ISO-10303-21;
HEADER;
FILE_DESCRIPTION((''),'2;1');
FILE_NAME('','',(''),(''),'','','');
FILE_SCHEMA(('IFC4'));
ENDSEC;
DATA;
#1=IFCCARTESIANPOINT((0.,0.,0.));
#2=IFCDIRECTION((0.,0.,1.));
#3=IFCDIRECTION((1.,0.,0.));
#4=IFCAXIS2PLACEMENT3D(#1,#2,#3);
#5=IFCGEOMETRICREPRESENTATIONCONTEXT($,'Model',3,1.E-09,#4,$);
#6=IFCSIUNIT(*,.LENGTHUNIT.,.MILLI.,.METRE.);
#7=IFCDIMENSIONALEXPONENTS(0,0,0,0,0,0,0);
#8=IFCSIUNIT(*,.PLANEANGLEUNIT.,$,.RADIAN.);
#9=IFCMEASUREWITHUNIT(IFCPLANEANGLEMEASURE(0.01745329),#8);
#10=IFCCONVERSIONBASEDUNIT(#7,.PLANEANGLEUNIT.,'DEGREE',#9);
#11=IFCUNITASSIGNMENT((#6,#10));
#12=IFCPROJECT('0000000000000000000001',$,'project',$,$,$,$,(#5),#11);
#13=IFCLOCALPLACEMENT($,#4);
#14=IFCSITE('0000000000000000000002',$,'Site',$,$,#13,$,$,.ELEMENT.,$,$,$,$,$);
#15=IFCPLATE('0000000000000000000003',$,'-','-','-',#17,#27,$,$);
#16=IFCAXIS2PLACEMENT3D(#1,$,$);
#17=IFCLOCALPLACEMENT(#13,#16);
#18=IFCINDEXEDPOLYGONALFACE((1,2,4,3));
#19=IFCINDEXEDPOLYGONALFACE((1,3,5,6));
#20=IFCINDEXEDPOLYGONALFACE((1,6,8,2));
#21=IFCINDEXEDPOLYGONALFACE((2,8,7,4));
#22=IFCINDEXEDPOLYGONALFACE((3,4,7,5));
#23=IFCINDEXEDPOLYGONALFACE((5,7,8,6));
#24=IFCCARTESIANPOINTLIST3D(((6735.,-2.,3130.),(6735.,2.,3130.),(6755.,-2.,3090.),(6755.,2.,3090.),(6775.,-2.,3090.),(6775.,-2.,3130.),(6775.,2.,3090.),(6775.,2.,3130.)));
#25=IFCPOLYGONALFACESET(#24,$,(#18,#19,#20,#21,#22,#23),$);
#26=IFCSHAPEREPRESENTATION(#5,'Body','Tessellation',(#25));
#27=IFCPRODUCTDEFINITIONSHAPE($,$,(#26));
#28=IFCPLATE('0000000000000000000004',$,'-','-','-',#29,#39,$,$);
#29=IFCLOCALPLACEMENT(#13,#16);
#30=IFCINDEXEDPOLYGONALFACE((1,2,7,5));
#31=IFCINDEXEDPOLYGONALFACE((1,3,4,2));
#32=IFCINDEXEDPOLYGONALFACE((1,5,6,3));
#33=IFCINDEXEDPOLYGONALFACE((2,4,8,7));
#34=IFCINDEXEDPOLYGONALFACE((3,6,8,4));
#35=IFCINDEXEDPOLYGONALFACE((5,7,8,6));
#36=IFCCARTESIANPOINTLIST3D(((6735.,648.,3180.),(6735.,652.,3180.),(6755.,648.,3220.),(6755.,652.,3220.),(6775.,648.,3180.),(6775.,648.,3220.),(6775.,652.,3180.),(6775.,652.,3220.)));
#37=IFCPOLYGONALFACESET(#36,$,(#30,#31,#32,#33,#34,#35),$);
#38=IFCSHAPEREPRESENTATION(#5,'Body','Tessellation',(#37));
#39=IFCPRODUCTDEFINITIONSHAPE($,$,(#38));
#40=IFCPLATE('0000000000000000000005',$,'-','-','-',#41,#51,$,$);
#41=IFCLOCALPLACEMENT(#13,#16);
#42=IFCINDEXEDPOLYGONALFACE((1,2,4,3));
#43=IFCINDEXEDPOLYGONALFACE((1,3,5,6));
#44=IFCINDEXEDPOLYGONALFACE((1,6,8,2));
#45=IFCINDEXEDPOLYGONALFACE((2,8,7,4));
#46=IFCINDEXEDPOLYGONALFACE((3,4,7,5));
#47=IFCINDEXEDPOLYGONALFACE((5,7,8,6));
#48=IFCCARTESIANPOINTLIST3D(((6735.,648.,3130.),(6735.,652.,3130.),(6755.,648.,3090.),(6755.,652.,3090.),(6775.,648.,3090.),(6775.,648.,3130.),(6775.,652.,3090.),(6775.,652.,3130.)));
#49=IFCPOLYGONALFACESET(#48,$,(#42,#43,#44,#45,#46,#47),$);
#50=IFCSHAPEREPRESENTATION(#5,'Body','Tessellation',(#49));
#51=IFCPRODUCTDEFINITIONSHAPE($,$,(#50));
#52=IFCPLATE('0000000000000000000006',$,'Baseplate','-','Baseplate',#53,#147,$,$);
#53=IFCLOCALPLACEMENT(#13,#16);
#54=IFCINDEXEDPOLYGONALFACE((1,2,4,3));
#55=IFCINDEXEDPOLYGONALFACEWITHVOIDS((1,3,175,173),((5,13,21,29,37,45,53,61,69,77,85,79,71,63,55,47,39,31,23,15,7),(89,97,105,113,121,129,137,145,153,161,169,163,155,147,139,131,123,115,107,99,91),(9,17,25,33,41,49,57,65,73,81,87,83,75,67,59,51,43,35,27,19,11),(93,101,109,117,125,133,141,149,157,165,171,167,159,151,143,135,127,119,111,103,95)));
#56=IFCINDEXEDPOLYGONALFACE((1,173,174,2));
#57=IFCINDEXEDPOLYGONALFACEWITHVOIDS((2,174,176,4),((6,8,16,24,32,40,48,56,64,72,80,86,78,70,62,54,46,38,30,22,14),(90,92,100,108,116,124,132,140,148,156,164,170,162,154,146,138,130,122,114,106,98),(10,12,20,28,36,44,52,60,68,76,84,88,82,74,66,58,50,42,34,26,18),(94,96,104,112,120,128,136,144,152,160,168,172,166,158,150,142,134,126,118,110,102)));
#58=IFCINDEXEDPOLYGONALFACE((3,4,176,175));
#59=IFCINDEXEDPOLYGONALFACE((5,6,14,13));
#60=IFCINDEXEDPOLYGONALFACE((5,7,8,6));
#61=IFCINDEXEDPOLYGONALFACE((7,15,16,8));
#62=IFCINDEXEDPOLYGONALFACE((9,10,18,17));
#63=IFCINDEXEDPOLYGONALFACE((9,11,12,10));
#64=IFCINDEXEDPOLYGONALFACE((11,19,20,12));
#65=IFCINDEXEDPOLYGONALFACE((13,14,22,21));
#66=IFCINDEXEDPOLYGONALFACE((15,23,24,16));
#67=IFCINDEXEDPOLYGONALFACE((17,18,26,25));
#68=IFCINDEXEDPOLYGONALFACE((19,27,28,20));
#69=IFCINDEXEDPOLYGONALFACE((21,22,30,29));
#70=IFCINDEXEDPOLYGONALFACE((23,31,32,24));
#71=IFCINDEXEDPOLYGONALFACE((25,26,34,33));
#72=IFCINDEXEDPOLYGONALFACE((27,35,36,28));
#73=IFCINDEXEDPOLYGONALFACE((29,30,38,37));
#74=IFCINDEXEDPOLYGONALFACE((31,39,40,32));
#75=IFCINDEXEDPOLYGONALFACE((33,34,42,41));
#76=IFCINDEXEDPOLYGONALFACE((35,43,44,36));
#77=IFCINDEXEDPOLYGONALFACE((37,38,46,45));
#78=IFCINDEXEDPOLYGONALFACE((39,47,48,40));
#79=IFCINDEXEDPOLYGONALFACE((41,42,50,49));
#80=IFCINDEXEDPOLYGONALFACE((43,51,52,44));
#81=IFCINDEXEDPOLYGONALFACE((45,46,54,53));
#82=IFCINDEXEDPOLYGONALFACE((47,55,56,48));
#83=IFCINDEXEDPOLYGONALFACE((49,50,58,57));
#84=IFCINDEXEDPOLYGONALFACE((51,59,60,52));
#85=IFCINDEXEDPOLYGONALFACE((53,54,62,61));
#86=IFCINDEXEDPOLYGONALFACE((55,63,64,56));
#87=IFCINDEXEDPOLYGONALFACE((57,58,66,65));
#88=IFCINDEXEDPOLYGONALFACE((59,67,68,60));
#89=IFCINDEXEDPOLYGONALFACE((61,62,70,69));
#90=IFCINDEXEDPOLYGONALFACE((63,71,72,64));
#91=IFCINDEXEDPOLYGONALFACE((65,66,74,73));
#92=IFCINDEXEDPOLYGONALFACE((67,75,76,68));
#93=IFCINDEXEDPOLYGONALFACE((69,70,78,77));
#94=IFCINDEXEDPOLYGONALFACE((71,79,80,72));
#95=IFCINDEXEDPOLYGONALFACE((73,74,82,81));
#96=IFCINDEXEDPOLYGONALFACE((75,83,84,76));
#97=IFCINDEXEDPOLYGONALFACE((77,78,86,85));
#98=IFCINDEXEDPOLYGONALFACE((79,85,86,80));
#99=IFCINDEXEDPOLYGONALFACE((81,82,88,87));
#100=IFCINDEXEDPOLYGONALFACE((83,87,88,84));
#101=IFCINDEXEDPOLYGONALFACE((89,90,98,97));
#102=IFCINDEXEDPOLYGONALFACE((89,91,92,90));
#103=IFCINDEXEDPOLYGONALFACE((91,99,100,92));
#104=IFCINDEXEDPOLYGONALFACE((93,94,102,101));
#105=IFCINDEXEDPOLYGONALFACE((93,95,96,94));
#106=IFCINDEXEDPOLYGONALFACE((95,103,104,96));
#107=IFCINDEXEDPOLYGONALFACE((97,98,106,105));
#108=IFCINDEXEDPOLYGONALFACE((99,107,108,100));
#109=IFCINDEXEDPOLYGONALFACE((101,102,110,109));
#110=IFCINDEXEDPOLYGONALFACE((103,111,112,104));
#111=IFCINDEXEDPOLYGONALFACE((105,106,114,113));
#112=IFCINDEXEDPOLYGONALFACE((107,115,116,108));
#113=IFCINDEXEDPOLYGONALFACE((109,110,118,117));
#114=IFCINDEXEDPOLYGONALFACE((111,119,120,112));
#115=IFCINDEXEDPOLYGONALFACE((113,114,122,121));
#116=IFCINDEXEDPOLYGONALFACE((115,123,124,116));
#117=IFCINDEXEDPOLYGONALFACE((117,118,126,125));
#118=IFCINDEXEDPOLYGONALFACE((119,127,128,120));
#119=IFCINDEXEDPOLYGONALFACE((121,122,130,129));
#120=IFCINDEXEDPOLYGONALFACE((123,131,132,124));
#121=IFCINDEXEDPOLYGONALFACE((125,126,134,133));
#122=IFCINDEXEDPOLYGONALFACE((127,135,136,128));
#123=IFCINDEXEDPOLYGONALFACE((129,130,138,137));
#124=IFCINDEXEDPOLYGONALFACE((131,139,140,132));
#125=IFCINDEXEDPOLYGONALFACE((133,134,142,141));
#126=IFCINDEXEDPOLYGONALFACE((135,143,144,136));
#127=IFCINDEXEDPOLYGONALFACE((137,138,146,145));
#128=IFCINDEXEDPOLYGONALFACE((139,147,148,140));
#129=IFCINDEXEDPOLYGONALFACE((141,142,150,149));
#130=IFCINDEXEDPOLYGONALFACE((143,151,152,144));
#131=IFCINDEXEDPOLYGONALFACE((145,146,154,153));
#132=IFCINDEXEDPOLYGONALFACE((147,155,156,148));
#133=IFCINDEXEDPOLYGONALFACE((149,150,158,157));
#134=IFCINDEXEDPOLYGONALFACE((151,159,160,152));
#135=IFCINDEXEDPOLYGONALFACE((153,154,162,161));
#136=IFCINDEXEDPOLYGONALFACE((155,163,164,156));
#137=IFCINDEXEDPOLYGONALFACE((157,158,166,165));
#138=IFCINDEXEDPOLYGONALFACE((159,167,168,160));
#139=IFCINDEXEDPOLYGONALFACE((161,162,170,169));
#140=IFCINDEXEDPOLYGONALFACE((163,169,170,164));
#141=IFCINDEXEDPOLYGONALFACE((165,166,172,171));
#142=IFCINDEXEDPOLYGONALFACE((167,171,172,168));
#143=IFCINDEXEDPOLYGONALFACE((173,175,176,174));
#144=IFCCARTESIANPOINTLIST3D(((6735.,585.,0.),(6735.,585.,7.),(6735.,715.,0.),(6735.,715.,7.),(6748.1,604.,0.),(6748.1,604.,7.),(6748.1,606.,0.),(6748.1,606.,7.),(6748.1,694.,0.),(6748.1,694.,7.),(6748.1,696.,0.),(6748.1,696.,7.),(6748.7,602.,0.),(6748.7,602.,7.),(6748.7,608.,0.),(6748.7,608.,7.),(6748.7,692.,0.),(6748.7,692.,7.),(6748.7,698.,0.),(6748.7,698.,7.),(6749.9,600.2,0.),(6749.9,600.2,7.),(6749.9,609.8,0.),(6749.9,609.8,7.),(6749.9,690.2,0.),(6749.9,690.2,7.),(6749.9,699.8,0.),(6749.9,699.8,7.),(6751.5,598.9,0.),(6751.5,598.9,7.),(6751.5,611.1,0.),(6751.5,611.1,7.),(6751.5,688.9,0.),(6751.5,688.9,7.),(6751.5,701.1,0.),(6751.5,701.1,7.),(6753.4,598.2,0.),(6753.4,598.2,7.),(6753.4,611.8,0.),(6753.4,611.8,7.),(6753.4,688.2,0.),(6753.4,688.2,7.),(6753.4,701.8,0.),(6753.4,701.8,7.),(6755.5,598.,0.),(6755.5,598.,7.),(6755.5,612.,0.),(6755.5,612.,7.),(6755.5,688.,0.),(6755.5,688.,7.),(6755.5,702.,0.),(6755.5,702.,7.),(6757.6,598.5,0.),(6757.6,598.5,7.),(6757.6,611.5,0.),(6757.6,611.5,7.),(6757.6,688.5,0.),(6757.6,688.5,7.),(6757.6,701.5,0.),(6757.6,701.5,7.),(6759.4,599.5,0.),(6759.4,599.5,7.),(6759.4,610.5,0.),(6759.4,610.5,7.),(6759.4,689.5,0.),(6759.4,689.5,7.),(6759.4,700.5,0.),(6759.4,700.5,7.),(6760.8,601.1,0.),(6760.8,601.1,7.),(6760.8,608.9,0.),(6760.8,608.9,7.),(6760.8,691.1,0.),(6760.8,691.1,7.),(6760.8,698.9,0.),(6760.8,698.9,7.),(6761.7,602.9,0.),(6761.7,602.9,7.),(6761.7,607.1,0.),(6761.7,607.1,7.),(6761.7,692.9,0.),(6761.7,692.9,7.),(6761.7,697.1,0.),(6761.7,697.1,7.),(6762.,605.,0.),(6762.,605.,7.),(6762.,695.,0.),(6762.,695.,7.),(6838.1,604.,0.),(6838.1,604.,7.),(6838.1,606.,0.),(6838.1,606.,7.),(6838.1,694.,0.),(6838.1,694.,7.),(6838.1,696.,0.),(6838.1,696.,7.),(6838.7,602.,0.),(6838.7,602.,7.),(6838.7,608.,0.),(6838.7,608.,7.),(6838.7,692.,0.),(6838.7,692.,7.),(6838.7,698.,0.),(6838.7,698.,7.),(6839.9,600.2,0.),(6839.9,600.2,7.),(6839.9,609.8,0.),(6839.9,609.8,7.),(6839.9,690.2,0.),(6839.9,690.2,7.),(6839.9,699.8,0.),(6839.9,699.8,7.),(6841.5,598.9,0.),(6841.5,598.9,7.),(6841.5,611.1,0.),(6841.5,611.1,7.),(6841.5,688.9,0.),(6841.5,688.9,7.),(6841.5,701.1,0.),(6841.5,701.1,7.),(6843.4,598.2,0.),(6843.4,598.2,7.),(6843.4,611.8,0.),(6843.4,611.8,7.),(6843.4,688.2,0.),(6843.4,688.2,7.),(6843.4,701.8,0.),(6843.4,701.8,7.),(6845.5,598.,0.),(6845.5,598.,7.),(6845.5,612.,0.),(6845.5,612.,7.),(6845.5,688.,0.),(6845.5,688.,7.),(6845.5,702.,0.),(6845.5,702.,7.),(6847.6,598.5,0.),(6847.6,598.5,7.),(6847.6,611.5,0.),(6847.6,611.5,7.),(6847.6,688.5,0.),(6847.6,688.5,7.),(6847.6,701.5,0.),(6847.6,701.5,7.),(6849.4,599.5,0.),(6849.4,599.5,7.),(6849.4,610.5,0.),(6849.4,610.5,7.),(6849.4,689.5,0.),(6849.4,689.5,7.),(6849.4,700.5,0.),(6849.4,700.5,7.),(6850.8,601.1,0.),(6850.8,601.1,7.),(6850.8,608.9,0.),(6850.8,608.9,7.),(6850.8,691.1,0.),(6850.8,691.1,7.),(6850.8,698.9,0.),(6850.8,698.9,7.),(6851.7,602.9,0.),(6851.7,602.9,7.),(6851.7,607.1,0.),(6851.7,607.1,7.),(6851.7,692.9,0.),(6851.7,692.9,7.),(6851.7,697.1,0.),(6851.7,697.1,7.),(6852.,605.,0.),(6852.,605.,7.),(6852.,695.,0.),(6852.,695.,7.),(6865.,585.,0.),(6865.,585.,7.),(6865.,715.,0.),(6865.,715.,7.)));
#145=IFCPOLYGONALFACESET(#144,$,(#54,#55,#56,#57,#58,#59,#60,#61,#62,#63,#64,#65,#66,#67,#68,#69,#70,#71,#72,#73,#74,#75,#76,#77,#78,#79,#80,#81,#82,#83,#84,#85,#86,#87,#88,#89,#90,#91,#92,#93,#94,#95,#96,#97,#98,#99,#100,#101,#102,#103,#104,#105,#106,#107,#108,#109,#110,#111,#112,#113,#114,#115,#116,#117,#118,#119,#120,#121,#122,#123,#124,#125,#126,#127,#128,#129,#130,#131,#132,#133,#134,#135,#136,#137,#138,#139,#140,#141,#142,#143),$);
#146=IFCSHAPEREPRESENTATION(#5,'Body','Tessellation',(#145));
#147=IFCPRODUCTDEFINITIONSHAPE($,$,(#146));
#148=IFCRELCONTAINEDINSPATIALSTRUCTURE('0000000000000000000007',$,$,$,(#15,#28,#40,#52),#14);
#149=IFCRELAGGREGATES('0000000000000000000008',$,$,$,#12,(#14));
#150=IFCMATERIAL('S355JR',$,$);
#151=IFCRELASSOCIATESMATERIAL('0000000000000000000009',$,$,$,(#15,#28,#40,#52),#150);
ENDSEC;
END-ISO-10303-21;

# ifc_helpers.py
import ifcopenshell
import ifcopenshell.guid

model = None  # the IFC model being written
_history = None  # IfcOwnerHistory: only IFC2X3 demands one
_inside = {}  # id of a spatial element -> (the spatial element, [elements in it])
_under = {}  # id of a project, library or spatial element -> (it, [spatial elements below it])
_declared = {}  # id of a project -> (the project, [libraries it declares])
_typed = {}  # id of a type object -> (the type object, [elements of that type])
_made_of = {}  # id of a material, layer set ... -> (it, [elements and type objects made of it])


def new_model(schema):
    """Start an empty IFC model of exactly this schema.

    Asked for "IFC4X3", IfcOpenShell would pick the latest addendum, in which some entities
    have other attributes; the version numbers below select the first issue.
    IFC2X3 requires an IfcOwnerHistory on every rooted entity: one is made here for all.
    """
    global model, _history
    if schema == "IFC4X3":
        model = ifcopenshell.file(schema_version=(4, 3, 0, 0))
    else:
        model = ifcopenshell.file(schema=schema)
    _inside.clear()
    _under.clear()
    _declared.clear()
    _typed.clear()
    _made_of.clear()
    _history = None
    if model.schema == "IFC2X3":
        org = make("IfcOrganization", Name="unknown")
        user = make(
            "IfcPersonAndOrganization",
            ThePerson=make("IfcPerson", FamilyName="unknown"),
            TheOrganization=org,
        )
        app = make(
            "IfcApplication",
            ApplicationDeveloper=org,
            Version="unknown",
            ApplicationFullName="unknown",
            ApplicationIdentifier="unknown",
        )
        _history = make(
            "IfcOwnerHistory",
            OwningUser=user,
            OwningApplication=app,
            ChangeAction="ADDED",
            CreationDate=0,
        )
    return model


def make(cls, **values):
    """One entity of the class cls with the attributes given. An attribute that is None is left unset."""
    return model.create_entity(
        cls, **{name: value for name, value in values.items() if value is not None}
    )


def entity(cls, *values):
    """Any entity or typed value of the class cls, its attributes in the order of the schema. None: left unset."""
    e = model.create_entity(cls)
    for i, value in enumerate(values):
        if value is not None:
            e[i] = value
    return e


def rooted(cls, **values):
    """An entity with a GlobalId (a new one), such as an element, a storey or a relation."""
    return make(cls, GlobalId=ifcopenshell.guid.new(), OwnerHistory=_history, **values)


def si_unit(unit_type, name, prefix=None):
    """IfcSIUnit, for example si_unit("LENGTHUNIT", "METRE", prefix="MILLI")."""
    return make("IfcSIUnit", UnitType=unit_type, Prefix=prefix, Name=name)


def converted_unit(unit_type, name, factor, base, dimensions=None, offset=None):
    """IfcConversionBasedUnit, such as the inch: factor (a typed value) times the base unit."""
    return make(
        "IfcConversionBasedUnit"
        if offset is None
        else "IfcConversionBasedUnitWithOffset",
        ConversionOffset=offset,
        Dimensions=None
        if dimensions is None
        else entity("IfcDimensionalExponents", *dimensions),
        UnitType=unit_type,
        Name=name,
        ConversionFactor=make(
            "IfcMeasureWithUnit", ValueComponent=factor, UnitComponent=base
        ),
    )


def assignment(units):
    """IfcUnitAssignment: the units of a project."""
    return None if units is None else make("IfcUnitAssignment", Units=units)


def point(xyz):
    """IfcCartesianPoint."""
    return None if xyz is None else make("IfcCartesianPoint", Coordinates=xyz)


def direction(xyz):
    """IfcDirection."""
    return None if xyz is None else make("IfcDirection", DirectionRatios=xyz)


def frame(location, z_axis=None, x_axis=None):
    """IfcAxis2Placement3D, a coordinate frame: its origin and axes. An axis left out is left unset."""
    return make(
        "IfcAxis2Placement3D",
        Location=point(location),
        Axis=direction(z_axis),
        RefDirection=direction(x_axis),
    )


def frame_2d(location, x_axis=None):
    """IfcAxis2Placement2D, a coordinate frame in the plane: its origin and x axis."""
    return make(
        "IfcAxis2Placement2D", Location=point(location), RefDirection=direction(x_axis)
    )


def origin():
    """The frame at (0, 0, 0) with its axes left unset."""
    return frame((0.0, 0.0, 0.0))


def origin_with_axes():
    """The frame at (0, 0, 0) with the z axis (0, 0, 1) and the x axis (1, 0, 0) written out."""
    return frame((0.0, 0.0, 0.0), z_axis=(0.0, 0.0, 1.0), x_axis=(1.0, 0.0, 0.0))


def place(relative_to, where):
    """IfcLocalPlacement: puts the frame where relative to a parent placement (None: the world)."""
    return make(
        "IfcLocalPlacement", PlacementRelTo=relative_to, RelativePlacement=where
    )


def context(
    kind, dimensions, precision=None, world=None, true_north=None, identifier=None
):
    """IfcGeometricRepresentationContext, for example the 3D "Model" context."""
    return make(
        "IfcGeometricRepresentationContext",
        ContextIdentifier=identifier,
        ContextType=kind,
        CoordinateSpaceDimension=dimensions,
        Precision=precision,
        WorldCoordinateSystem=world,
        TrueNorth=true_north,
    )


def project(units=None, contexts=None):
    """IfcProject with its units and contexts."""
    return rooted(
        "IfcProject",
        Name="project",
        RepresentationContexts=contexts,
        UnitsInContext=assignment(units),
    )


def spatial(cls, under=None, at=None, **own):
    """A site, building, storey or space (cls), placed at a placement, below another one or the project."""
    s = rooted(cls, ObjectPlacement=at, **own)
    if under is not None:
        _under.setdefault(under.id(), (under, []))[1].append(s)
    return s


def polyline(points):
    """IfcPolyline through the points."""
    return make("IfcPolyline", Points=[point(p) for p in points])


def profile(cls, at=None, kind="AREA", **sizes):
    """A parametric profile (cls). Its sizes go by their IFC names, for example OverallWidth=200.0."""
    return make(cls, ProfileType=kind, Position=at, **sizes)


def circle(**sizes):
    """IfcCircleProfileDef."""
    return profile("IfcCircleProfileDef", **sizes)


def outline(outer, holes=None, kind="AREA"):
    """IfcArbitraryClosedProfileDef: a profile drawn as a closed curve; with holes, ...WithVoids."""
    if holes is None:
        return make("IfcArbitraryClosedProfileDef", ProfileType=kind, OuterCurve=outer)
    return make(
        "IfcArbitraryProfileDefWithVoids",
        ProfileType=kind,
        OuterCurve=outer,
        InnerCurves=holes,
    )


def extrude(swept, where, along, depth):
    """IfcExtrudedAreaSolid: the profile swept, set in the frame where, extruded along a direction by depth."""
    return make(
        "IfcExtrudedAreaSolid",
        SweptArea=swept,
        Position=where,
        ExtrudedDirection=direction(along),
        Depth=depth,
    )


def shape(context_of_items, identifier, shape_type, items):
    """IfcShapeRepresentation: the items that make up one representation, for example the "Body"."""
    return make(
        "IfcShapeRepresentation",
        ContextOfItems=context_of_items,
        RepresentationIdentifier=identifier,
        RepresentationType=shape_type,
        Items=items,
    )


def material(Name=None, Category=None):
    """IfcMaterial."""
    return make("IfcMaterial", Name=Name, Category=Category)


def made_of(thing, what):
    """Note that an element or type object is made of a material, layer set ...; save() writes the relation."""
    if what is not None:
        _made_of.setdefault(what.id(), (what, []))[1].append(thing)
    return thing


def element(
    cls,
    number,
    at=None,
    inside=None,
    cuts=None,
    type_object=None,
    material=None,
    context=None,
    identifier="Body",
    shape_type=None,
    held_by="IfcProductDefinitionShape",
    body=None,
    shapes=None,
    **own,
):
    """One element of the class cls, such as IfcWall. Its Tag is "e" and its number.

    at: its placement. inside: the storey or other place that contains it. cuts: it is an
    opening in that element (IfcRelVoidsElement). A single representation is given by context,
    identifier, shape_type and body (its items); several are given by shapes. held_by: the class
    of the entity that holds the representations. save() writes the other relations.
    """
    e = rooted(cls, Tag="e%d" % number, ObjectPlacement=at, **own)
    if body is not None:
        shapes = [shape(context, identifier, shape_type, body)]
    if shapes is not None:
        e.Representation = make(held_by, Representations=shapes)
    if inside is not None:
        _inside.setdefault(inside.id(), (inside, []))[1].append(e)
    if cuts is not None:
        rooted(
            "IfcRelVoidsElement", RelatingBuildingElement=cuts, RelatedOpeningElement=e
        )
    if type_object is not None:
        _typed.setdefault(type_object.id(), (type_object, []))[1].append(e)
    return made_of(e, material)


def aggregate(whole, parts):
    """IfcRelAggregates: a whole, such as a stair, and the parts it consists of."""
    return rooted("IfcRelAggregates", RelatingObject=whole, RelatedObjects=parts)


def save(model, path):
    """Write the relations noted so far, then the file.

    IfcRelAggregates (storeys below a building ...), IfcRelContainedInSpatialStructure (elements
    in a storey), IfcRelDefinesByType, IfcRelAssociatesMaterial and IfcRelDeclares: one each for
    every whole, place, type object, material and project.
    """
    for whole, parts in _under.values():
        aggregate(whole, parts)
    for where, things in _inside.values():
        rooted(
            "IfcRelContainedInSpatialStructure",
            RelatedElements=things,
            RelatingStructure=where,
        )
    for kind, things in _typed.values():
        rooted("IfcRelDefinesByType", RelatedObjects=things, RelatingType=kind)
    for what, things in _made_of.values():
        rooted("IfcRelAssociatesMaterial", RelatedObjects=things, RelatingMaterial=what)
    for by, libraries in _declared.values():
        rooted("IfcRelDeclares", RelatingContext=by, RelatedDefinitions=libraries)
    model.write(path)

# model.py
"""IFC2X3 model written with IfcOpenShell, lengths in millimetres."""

from ifc_helpers import new_model, entity, si_unit, converted_unit, frame, frame_2d, origin, origin_with_axes, place, context, project, spatial, polyline, circle, outline, extrude, material, element, save


model = new_model("IFC2X3")

# Units and contexts
model_context = context("Model", 3, precision=1e-09, world=origin_with_axes())
ifc_project = project(units=[si_unit("LENGTHUNIT", "METRE", prefix="MILLI"), converted_unit("PLANEANGLEUNIT", "DEGREE", entity("IfcPlaneAngleMeasure", 0.01745329), si_unit("PLANEANGLEUNIT", "RADIAN"), dimensions=[0, 0, 0, 0, 0, 0, 0])], contexts=[model_context])

# Site
site_placement = place(None, origin_with_axes())
site = spatial("IfcSite", under=ifc_project, at=site_placement, Name="Site", CompositionType="ELEMENT")

# Shared definitions
ifc_material = material(Name="S355JR")

# Plates
for number, where, z_axis, x_axis, name in (
    (1, (6775.0, -2.0, 3130.0), (0.0, 1.0, 0.0), (0.0, 0.0, -1.0), "-"),
    (2, (6775.0, 652.0, 3180.0), (0.0, -1.0, 0.0), (0.0, 0.0, 1.0), "-"),
):
    element("IfcPlate", number, at=place(None, frame(where, z_axis=z_axis, x_axis=x_axis)), inside=site, material=ifc_material, Name=name, Description="-", ObjectType="-", context=model_context, shape_type="SweptSolid", body=[
        extrude(outline(polyline([(0.0, 0.0), (40.0, 0.0), (40.0, 20.0), (0.0, 40.0), (0.0, 0.0)])), origin_with_axes(), (0.0, 0.0, 1.0), 4.0),
    ])
plate_1_placement = place(None, frame((6775.0, 652.0, 3130.0), z_axis=(0.0, 1.0, 0.0), x_axis=(0.0, 0.0, -1.0)))
element("IfcPlate", 3, at=plate_1_placement, inside=site, material=ifc_material, Name="-", Description="-", ObjectType="-", context=model_context, shape_type="SweptSolid", body=[
    extrude(outline(polyline([(0.0, 0.0), (40.0, 0.0), (40.0, 20.0), (0.0, 40.0), (0.0, 0.0)])), origin_with_axes(), (0.0, 0.0, -1.0), 4.0),
])

# Plate, openings
plate_2_placement = place(None, frame((6735.0, 715.0, 7.0), z_axis=(0.0, 0.0, -1.0), x_axis=(1.0, 0.0, 0.0)))
plate_2 = element("IfcPlate", 4, at=plate_2_placement, inside=site, material=ifc_material, Name="Baseplate", Description="-", ObjectType="Baseplate", context=model_context, shape_type="SweptSolid", body=[
    extrude(outline(polyline([(0.0, 0.0), (130.0, 0.0), (130.0, 130.0), (0.0, 130.0), (0.0, 0.0)])), origin_with_axes(), (0.0, 0.0, 1.0), 7.0),
])
opening_1_placement = place(plate_2_placement, frame((20.0, 65.0, 7.5), z_axis=(0.0, 0.0, -1.0), x_axis=(1.0, 0.0, 0.0)))
element("IfcOpeningElement", 5, at=opening_1_placement, cuts=plate_2, ObjectType="Opening", context=model_context, shape_type="SweptSolid", body=[
    extrude(circle(Radius=7.0, at=frame_2d((0.0, 45.0), x_axis=(1.0, 0.0))), origin(), (0.0, 0.0, 1.0), 8.0),
])
opening_2_placement = place(plate_2_placement, frame((20.0, 65.0, 7.5), z_axis=(0.0, 0.0, -1.0), x_axis=(1.0, 0.0, 0.0)))
element("IfcOpeningElement", 6, at=opening_2_placement, cuts=plate_2, ObjectType="Opening", context=model_context, shape_type="SweptSolid", body=[
    extrude(circle(Radius=7.0, at=frame_2d((0.0, -45.0), x_axis=(1.0, 0.0))), origin(), (0.0, 0.0, 1.0), 8.0),
])
opening_3_placement = place(plate_2_placement, frame((110.0, 65.0, 7.5), z_axis=(0.0, 0.0, -1.0), x_axis=(1.0, 0.0, 0.0)))
element("IfcOpeningElement", 7, at=opening_3_placement, cuts=plate_2, ObjectType="Opening", context=model_context, shape_type="SweptSolid", body=[
    extrude(circle(Radius=7.0, at=frame_2d((0.0, 45.0), x_axis=(1.0, 0.0))), origin(), (0.0, 0.0, 1.0), 8.0),
])
opening_4_placement = place(plate_2_placement, frame((110.0, 65.0, 7.5), z_axis=(0.0, 0.0, -1.0), x_axis=(1.0, 0.0, 0.0)))
element("IfcOpeningElement", 8, at=opening_4_placement, cuts=plate_2, ObjectType="Opening", context=model_context, shape_type="SweptSolid", body=[
    extrude(circle(Radius=7.0, at=frame_2d((0.0, -45.0), x_axis=(1.0, 0.0))), origin(), (0.0, 0.0, 1.0), 8.0),
])

save(model, "model.ifc")
